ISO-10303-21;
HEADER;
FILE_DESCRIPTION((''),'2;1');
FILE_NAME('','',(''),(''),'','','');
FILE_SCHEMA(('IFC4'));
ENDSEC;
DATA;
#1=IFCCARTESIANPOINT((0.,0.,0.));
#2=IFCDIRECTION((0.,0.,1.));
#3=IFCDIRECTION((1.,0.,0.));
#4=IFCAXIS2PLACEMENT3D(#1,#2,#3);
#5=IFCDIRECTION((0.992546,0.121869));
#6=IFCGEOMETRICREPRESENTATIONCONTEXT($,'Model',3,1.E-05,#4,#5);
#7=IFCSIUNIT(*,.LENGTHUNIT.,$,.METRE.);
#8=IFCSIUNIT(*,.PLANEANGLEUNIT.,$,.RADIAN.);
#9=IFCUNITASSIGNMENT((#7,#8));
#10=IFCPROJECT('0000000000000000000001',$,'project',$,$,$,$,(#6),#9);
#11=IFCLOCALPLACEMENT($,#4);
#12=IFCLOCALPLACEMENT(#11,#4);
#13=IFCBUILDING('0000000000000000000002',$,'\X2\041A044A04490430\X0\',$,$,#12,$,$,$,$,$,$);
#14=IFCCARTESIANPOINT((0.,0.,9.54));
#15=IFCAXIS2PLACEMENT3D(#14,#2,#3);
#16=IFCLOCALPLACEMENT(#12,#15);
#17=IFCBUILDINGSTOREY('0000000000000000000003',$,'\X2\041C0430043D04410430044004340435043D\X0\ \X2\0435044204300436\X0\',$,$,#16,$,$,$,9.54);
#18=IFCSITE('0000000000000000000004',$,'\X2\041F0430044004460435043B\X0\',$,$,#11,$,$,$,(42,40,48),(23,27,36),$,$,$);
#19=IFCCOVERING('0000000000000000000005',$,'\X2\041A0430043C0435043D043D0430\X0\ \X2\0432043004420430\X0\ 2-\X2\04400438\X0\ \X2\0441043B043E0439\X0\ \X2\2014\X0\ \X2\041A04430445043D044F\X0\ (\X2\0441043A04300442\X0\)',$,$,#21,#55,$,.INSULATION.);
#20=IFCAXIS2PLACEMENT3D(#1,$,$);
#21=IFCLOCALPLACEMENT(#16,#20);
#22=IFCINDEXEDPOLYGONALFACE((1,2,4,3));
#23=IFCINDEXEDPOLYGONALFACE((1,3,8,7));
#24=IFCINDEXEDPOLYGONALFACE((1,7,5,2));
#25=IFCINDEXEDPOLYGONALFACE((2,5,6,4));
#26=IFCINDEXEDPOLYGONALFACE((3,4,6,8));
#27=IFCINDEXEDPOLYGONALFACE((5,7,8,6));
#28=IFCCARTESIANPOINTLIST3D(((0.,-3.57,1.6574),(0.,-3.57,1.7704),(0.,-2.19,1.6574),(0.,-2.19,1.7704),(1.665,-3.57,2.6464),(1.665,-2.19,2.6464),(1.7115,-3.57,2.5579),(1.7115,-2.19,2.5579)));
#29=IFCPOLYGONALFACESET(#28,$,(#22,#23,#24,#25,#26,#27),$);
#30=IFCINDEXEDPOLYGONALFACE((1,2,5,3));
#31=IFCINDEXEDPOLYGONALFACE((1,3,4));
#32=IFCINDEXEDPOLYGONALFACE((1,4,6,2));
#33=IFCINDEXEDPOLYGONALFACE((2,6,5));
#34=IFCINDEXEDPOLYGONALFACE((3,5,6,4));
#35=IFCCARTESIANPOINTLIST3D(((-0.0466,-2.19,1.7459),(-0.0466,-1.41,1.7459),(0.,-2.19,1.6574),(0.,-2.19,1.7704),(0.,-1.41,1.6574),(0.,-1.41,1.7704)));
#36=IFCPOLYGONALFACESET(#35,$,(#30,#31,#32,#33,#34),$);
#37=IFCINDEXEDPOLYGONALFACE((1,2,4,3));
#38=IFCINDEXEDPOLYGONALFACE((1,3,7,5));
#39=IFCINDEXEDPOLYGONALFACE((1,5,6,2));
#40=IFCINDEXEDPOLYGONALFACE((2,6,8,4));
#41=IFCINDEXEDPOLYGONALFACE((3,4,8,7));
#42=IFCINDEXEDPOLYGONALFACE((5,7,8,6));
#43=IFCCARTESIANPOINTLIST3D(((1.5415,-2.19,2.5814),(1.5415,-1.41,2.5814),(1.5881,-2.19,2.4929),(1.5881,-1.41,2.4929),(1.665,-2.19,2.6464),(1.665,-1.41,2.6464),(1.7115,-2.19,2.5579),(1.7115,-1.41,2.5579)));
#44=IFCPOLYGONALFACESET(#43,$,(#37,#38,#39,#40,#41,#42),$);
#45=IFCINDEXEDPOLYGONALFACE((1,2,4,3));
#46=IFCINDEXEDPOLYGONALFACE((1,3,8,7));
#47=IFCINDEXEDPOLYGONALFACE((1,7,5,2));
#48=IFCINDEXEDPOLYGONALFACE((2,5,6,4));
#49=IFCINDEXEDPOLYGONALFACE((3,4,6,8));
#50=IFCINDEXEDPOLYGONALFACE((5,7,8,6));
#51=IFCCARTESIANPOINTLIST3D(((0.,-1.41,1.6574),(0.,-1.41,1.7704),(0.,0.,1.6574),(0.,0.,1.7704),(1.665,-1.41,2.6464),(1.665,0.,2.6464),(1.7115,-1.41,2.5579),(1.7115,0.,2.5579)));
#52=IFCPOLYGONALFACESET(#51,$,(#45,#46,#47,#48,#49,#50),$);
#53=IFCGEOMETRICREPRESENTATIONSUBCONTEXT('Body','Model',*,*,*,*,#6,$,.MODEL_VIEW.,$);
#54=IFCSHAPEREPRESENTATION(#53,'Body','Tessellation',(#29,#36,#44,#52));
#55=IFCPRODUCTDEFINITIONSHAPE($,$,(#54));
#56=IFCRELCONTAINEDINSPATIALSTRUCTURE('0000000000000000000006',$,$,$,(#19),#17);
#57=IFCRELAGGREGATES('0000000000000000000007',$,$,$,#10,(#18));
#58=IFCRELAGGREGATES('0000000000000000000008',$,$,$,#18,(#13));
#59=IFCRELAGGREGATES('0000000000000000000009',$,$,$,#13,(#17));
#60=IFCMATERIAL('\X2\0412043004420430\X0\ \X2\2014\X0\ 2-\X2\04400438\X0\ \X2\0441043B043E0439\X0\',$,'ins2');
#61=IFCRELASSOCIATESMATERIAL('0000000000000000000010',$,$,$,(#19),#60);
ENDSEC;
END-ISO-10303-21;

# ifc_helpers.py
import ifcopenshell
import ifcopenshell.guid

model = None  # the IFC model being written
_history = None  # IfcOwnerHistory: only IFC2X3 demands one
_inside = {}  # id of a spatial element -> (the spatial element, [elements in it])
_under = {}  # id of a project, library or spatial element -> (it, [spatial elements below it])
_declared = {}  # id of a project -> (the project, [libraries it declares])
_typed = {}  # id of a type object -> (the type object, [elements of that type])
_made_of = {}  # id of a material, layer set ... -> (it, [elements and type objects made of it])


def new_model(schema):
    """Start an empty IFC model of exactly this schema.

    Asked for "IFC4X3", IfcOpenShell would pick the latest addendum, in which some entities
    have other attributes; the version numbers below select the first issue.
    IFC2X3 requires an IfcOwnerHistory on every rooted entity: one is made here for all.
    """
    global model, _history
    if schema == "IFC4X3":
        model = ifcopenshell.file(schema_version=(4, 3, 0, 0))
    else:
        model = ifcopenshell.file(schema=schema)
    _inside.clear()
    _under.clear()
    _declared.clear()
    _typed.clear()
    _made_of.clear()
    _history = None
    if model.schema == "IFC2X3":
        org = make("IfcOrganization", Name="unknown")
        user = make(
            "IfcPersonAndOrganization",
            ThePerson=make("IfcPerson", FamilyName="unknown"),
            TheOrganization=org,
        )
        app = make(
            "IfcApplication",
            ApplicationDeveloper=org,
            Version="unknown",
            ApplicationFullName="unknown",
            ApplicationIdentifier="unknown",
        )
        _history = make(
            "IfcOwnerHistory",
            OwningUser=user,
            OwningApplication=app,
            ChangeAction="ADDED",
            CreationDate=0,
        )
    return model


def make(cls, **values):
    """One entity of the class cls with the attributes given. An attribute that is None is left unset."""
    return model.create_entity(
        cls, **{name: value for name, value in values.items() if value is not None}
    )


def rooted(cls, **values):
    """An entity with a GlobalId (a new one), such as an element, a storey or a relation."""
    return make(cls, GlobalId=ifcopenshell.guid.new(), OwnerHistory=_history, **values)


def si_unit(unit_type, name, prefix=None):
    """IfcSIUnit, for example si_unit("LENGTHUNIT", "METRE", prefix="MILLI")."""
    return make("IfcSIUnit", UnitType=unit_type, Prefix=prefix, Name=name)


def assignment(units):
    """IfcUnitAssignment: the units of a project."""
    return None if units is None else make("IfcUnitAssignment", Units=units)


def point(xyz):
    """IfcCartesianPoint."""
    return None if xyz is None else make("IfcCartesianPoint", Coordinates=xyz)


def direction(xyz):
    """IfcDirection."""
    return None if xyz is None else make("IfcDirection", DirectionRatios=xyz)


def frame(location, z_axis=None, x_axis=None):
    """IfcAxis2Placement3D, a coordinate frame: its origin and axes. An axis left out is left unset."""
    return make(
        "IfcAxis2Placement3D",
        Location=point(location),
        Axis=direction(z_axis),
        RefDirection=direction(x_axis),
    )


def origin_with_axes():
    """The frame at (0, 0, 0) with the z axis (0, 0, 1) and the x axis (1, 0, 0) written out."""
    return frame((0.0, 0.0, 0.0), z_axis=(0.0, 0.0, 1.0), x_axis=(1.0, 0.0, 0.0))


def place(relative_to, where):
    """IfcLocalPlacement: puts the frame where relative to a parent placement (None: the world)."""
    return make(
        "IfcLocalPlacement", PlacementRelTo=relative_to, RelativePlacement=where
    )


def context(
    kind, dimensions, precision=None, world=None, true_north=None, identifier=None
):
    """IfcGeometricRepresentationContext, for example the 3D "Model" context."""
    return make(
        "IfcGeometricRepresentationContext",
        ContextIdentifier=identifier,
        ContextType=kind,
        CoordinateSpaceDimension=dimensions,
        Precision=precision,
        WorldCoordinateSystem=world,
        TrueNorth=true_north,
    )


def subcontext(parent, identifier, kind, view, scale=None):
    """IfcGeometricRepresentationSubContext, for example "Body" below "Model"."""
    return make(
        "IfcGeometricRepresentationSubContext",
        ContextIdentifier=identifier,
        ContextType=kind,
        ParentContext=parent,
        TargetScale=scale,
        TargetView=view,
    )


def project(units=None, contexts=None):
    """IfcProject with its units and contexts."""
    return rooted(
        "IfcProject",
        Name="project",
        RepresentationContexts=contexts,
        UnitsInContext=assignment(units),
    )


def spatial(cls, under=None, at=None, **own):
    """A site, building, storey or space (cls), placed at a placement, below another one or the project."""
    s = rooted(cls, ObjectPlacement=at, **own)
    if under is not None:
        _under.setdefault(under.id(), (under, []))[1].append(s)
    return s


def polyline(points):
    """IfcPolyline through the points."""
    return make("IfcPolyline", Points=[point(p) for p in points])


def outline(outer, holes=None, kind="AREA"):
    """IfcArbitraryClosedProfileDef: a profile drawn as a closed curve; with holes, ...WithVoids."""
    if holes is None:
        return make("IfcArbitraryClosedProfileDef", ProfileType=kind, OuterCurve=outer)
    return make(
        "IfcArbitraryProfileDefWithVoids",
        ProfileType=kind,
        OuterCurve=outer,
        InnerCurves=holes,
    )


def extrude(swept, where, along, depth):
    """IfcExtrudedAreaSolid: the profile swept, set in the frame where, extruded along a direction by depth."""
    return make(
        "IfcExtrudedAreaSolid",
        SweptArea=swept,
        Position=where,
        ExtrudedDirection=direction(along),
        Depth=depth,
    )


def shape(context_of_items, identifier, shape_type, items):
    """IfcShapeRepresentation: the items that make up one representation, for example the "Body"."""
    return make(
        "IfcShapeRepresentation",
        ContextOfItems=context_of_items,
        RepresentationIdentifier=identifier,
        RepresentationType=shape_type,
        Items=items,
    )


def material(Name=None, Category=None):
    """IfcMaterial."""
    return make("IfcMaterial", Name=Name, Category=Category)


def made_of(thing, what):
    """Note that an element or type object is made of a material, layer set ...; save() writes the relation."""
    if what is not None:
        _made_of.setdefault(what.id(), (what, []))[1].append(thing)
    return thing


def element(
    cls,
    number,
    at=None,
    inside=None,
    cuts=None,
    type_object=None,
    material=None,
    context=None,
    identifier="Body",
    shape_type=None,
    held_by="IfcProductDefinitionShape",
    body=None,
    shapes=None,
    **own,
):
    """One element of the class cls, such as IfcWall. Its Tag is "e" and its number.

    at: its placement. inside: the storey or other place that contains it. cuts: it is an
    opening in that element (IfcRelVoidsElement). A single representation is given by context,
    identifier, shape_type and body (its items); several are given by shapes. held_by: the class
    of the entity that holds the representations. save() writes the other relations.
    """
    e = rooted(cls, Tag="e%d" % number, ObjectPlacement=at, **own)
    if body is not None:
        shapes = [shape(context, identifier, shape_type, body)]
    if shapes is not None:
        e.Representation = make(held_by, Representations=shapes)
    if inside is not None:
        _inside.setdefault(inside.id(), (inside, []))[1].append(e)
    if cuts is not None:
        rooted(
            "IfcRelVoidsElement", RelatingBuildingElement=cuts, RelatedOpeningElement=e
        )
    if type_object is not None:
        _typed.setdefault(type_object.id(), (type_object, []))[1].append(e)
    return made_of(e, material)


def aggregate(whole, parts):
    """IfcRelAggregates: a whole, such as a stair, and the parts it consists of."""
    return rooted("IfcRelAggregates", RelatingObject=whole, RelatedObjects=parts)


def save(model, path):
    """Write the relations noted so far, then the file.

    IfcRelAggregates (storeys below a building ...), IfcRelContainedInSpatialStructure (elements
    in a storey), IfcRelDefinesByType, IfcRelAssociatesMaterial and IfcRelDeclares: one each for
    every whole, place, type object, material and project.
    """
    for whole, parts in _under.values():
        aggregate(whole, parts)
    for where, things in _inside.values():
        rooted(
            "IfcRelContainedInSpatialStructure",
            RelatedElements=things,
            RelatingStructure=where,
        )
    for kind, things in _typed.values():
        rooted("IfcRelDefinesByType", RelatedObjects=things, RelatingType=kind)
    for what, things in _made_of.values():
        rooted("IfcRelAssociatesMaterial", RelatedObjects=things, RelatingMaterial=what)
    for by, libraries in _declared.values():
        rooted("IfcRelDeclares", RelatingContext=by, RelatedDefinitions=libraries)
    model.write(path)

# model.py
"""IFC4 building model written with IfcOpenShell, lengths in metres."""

from ifc_helpers import new_model, si_unit, direction, frame, origin_with_axes, place, context, subcontext, project, spatial, polyline, outline, extrude, material, element, save


model = new_model("IFC4")

# Units and contexts
model_context = context("Model", 3, precision=1e-05, world=origin_with_axes(), true_north=direction((0.992546, 0.121869)))
body_context = subcontext(model_context, "Body", "Model", "MODEL_VIEW")
ifc_project = project(units=[si_unit("LENGTHUNIT", "METRE"), si_unit("PLANEANGLEUNIT", "RADIAN")], contexts=[model_context])

# Site, building, storey
site_placement = place(None, origin_with_axes())
site = spatial("IfcSite", under=ifc_project, at=site_placement, Name="Парцел", RefLatitude=(42, 40, 48), RefLongitude=(23, 27, 36))
building_placement = place(site_placement, origin_with_axes())
building = spatial("IfcBuilding", under=site, at=building_placement, Name="Къща")
storey_placement = place(building_placement, frame((0.0, 0.0, 9.54), z_axis=(0.0, 0.0, 1.0), x_axis=(1.0, 0.0, 0.0)))
storey = spatial("IfcBuildingStorey", under=building, at=storey_placement, Name="Мансарден етаж", Elevation=9.54)

# Covering
ifc_material_1 = material(Name="Вата — 2-ри слой", Category="ins2")
covering_1_placement = place(storey_placement, origin_with_axes())
element("IfcCovering", 1, at=covering_1_placement, inside=storey, material=ifc_material_1, Name="Каменна вата 2-ри слой — Кухня (скат)", PredefinedType="INSULATION", context=body_context, shape_type="SweptSolid", body=[
    extrude(outline(polyline([(0.0, -1.6574), (1.7115, -2.5579), (1.665, -2.6464), (0.0, -1.7704), (0.0, -1.6574)])), frame((0.0, -3.57, 0.0), z_axis=(0.0, 1.0, 0.0), x_axis=(1.0, 0.0, 0.0)), (0.0, 0.0, 1.0), 1.38),
    extrude(outline(polyline([(0.0, -1.6574), (-0.0466, -1.7459), (0.0, -1.7704), (0.0, -1.6574)])), frame((0.0, -2.19, 0.0), z_axis=(0.0, 1.0, 0.0), x_axis=(1.0, 0.0, 0.0)), (0.0, 0.0, 1.0), 0.78),
    extrude(outline(polyline([(1.5881, -2.4929), (1.7115, -2.5579), (1.665, -2.6464), (1.5415, -2.5814), (1.5881, -2.4929)])), frame((0.0, -2.19, 0.0), z_axis=(0.0, 1.0, 0.0), x_axis=(1.0, 0.0, 0.0)), (0.0, 0.0, 1.0), 0.78),
    extrude(outline(polyline([(0.0, -1.6574), (1.7115, -2.5579), (1.665, -2.6464), (0.0, -1.7704), (0.0, -1.6574)])), frame((0.0, -1.41, 0.0), z_axis=(0.0, 1.0, 0.0), x_axis=(1.0, 0.0, 0.0)), (0.0, 0.0, 1.0), 1.41),
])

save(model, "model.ifc")
